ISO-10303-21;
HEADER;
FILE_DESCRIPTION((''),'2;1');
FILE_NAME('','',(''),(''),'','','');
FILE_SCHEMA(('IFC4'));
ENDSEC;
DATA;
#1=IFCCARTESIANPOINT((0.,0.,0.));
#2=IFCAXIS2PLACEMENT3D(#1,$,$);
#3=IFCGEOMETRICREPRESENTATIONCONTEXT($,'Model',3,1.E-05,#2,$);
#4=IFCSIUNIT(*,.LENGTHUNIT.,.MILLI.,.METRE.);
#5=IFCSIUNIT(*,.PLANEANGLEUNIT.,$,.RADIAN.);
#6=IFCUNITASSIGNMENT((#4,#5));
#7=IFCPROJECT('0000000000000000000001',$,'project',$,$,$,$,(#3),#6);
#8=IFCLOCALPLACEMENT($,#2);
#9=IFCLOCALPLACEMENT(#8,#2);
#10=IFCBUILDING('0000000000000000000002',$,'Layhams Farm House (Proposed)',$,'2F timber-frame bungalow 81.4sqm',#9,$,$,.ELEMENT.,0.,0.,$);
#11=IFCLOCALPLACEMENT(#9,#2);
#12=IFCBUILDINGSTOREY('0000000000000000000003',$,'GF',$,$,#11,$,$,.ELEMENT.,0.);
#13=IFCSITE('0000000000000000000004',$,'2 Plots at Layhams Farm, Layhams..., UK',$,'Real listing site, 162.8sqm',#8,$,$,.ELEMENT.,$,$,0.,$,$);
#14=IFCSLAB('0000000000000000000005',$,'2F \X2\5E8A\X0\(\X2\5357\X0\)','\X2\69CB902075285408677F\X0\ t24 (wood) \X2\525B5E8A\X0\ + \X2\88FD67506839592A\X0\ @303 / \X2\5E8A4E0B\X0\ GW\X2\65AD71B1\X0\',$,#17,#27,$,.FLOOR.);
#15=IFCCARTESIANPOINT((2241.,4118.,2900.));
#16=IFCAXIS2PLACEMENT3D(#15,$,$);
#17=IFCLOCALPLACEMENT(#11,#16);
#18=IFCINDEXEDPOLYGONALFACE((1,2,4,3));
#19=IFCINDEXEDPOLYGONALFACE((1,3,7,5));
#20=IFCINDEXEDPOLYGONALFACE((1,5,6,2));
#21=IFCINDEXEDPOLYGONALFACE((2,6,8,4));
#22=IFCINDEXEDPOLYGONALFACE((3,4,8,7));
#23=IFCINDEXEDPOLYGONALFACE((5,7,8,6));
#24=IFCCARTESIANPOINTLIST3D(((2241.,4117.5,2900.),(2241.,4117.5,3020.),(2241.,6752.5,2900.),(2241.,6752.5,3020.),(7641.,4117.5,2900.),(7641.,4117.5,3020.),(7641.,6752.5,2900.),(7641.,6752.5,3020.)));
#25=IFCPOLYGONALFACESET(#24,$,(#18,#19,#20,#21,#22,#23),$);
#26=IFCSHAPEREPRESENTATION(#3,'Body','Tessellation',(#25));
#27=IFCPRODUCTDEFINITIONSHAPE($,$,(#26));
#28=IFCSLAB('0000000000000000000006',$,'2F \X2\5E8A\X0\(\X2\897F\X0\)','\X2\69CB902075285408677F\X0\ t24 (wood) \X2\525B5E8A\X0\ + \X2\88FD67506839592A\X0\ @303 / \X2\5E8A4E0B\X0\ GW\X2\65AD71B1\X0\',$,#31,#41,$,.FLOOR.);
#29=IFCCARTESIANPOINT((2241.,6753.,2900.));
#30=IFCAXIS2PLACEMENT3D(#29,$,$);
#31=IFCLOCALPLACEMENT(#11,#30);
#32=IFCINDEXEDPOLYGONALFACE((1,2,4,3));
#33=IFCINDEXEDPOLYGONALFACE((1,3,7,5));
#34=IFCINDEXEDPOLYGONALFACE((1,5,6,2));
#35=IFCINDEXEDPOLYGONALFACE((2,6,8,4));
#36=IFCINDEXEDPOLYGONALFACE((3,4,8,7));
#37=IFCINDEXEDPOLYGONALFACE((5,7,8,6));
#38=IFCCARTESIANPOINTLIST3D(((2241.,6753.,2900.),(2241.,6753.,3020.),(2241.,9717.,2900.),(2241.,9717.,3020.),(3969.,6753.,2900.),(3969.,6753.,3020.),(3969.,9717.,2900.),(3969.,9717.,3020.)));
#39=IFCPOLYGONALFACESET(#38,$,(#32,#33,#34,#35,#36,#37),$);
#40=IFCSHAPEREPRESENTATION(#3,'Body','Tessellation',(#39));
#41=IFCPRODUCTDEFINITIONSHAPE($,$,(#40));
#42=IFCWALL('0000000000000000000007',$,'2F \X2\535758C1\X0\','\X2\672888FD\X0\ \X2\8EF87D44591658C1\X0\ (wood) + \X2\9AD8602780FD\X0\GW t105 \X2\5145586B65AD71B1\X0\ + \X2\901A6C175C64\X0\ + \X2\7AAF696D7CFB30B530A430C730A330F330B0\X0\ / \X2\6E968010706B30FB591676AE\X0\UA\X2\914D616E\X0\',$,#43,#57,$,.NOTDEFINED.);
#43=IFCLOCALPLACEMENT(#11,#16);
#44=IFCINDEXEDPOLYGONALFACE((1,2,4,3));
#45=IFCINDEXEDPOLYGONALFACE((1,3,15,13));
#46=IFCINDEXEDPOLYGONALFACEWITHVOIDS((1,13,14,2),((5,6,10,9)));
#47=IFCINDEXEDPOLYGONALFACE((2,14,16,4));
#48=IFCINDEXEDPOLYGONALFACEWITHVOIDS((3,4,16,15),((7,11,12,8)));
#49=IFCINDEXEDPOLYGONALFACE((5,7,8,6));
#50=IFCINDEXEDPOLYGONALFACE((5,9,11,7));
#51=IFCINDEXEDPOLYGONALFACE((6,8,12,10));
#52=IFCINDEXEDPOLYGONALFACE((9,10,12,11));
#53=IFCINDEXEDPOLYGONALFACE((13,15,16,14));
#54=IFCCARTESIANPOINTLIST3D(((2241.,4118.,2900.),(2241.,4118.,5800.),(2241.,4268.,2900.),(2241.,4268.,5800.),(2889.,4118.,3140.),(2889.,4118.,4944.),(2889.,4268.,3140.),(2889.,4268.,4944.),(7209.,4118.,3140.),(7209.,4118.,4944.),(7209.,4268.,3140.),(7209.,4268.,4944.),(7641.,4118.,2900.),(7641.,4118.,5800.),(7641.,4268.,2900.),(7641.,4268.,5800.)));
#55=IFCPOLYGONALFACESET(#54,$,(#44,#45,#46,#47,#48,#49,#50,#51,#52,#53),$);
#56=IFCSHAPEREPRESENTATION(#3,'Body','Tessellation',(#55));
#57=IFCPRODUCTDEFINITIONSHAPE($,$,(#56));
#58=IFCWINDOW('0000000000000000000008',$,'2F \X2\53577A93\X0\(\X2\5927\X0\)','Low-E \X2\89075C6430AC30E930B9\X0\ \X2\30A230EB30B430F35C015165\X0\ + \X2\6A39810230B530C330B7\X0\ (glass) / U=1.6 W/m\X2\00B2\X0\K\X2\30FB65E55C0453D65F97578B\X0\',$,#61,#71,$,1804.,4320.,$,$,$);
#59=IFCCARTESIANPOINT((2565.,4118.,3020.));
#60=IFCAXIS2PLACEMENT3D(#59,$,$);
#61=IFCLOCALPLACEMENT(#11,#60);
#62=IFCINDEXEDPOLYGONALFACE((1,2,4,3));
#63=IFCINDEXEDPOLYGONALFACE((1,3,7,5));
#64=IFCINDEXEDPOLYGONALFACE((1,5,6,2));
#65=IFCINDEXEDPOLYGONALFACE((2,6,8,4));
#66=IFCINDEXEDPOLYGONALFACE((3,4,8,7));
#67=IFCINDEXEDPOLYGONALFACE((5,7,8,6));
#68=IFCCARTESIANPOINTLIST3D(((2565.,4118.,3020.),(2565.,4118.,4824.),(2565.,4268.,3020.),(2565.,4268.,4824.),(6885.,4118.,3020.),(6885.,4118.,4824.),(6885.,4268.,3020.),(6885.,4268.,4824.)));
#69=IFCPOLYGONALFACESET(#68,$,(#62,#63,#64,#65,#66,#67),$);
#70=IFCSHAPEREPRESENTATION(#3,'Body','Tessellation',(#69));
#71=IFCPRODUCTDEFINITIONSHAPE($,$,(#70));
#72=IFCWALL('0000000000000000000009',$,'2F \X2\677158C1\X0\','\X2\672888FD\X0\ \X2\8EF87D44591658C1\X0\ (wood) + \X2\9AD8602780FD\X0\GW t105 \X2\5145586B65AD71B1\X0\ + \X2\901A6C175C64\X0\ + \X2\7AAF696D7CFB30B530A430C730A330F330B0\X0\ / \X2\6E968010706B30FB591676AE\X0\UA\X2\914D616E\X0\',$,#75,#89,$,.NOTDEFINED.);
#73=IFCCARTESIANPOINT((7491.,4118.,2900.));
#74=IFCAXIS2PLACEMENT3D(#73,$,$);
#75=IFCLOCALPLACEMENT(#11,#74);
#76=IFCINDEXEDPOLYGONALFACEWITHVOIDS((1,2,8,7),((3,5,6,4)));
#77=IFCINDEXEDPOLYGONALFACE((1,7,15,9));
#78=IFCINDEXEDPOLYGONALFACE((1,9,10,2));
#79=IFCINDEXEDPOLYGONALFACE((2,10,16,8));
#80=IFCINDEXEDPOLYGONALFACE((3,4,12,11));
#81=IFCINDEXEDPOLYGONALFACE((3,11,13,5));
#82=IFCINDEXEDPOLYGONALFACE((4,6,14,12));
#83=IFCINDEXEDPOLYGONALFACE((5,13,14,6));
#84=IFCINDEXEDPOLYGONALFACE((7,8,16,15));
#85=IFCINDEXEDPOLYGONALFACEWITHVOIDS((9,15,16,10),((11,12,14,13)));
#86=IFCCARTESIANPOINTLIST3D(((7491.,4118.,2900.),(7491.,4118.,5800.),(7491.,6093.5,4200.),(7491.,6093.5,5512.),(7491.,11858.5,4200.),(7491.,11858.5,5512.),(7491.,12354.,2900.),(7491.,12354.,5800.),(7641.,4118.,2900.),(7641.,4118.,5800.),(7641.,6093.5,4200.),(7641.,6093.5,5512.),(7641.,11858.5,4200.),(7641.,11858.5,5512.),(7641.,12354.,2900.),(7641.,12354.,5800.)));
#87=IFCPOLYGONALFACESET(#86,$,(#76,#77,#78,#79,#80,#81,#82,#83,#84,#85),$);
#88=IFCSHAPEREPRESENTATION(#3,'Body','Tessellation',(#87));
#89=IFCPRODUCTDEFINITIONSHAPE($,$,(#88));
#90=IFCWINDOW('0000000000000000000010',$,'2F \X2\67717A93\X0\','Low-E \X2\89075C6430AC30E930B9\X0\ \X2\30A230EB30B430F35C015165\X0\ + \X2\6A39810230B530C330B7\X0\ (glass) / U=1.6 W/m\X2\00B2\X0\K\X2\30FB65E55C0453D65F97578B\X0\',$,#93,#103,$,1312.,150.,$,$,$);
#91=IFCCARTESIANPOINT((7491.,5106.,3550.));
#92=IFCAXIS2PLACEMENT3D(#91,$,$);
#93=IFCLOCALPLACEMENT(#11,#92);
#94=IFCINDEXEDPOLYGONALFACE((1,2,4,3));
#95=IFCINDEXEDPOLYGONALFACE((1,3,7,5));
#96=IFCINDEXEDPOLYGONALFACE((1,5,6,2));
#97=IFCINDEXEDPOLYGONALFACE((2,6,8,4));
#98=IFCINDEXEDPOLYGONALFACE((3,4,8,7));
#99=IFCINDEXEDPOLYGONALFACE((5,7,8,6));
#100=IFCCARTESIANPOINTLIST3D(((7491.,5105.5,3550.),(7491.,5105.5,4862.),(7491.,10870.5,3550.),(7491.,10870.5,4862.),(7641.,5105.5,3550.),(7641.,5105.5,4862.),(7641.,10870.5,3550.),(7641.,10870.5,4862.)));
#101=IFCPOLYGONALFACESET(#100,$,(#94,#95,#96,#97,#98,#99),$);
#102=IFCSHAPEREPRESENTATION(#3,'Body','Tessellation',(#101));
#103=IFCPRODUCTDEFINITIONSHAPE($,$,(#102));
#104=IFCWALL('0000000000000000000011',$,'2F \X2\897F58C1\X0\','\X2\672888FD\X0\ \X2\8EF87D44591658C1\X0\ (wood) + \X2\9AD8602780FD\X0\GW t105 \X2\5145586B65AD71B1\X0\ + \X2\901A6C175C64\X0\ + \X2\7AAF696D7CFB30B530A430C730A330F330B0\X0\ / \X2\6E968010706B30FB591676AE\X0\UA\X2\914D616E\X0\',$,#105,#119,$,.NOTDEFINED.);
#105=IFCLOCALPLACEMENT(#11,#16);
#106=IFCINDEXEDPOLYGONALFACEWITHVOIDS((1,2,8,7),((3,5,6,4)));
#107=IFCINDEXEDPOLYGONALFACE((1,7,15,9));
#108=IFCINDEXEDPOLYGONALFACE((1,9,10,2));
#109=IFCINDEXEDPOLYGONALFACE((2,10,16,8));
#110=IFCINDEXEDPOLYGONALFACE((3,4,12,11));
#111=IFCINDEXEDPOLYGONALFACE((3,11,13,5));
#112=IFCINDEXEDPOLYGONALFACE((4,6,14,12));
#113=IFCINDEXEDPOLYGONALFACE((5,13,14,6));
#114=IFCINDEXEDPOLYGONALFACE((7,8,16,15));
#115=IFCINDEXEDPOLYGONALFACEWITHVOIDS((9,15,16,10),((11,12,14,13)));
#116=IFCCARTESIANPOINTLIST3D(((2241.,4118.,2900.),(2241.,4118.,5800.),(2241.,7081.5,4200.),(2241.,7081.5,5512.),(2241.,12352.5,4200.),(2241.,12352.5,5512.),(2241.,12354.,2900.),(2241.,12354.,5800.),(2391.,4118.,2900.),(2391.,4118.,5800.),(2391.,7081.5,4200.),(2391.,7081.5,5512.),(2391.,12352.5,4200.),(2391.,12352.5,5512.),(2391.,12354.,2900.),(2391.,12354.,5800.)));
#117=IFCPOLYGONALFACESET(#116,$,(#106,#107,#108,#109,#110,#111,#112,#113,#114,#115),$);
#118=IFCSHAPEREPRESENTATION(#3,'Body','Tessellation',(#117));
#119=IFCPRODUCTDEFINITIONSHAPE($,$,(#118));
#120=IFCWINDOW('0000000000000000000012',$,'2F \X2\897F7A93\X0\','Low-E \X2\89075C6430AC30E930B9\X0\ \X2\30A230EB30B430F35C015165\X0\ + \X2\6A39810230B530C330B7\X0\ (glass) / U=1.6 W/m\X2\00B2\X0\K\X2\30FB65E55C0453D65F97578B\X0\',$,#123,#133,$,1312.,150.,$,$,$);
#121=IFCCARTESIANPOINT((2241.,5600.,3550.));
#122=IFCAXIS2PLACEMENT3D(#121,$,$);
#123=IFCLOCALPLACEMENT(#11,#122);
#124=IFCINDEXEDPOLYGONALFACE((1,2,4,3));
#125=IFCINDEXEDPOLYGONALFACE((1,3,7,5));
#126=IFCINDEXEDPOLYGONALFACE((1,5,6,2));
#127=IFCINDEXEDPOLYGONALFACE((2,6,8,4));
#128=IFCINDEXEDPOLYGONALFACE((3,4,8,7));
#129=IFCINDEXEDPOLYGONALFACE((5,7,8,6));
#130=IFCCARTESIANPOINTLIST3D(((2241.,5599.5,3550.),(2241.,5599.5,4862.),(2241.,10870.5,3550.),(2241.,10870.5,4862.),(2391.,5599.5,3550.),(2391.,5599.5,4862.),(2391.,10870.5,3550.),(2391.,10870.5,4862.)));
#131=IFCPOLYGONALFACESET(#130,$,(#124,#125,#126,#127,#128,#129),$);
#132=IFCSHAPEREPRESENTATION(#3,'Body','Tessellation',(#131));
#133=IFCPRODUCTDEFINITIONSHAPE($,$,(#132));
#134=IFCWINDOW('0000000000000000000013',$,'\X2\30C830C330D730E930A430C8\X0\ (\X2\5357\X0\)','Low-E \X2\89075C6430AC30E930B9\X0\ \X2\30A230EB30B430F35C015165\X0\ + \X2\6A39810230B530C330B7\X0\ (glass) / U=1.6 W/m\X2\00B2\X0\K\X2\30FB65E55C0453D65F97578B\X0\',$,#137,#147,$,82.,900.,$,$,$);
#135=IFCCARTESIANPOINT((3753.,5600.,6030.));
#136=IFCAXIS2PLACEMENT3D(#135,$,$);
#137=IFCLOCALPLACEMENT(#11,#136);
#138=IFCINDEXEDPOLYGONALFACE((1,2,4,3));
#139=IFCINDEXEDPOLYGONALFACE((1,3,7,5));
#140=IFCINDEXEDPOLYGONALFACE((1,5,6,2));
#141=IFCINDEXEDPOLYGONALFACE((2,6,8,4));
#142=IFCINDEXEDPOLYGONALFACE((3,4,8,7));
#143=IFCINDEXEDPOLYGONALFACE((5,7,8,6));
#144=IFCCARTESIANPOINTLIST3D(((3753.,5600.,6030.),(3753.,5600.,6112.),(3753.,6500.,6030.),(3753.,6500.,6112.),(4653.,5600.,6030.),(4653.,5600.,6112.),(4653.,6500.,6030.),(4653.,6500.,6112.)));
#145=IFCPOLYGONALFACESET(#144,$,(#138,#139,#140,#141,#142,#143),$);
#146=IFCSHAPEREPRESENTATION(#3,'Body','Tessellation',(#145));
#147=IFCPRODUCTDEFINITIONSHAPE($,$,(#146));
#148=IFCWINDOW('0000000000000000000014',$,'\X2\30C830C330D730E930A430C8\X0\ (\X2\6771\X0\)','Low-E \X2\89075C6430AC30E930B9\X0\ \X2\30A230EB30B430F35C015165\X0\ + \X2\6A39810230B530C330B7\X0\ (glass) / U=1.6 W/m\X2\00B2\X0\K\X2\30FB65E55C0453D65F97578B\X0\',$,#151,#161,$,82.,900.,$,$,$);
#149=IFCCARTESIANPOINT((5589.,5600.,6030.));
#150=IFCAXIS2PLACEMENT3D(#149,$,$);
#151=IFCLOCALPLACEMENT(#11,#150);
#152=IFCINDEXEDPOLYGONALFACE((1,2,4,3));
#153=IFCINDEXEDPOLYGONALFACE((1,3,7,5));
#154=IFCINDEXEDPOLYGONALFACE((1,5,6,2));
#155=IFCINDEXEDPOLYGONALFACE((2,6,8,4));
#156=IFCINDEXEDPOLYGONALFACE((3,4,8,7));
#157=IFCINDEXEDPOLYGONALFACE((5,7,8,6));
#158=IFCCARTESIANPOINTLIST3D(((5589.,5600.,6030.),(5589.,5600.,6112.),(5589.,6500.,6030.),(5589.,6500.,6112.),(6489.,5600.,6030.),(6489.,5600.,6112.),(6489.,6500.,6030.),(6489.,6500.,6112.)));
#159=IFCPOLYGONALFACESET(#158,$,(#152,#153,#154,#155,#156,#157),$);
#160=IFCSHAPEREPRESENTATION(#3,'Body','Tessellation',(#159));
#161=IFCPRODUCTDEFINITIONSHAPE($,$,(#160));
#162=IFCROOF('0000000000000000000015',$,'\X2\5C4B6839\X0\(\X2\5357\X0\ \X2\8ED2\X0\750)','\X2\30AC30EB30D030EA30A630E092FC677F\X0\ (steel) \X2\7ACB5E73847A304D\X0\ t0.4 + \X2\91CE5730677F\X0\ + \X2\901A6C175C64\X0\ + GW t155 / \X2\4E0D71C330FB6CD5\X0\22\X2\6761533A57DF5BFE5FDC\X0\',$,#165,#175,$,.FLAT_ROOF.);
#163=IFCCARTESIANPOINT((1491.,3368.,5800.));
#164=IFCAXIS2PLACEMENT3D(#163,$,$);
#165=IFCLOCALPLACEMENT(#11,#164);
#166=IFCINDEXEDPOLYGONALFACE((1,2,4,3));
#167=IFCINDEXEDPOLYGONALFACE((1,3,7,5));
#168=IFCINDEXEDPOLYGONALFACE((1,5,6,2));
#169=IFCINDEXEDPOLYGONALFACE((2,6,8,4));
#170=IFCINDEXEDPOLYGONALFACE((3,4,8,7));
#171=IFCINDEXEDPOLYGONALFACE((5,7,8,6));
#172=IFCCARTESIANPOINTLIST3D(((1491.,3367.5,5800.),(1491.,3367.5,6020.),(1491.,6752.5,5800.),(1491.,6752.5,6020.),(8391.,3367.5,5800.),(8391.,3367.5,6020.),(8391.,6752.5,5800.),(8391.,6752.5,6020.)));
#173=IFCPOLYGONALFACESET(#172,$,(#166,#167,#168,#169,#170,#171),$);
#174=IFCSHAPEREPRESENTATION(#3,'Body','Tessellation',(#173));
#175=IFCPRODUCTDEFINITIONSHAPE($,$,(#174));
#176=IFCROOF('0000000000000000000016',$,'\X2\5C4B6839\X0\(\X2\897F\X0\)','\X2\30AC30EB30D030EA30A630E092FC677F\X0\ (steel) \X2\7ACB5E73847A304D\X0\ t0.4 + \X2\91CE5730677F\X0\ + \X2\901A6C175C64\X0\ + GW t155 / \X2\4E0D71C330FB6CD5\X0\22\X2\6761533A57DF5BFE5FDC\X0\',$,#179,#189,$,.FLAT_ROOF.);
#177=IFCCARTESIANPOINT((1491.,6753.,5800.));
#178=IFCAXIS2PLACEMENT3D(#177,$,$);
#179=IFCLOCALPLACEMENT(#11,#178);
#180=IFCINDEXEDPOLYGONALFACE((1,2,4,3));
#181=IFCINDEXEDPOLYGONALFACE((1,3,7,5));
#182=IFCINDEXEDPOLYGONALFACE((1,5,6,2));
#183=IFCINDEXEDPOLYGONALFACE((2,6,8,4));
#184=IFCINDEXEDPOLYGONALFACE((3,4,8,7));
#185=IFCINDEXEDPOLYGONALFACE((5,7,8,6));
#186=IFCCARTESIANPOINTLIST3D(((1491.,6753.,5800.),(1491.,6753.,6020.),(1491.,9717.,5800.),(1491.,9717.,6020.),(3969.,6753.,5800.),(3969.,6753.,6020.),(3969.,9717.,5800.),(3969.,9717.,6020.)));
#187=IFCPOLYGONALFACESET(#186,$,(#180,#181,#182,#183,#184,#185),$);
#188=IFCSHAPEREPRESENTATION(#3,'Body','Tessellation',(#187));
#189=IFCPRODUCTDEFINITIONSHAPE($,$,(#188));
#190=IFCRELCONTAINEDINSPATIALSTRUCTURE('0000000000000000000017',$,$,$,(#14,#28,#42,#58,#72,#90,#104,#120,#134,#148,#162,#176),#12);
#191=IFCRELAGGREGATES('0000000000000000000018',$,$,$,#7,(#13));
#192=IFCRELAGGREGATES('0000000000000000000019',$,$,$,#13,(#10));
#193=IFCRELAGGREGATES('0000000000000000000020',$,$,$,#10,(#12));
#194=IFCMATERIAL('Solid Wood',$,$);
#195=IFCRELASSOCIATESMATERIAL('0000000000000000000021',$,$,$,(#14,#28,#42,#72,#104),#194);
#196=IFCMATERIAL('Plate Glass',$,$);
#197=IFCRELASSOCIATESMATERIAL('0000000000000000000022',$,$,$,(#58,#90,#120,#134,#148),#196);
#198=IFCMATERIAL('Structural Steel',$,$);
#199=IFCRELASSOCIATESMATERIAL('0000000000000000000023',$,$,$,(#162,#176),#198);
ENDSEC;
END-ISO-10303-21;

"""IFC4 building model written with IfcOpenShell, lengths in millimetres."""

from ifc_helpers import new_model, si_unit, frame, frame_2d, origin, place, context, project, spatial, rectangle, extrude, material, element, fill, save


model = new_model("IFC4")

# Units and contexts
model_context = context("Model", 3, precision=1e-05, world=origin())
ifc_project = project(units=[si_unit("LENGTHUNIT", "METRE", prefix="MILLI"), si_unit("PLANEANGLEUNIT", "RADIAN")], contexts=[model_context])

# Site, building, storey
site_placement = place(None, origin())
site = spatial("IfcSite", under=ifc_project, at=site_placement, Name="2 Plots at Layhams Farm, Layhams..., UK", ObjectType="Real listing site, 162.8sqm", CompositionType="ELEMENT", RefElevation=0.0)
building_placement = place(site_placement, origin())
building = spatial("IfcBuilding", under=site, at=building_placement, Name="Layhams Farm House (Proposed)", ObjectType="2F timber-frame bungalow 81.4sqm", CompositionType="ELEMENT", ElevationOfRefHeight=0.0, ElevationOfTerrain=0.0)
storey_placement = place(building_placement, origin())
storey = spatial("IfcBuildingStorey", under=building, at=storey_placement, Name="GF", CompositionType="ELEMENT", Elevation=0.0)

# Slabs
ifc_material_1 = material(Name="Solid Wood")
slab_1_placement = place(storey_placement, frame((2241.0, 4118.0, 2900.0)))
element("IfcSlab", 1, at=slab_1_placement, inside=storey, material=ifc_material_1, Name="2F 床(南)", Description="構造用合板 t24 (wood) 剛床 + 製材根太 @303 / 床下 GW断熱", PredefinedType="FLOOR", context=model_context, shape_type="SweptSolid", body=[
    extrude(rectangle(XDim=5400.0, YDim=2635.0, at=frame_2d((2700.0, 1317.0))), frame((2241.0, 4118.0, 2900.0)), (0.0, 0.0, 1.0), 120.0),
])
slab_2_placement = place(storey_placement, frame((2241.0, 6753.0, 2900.0)))
element("IfcSlab", 2, at=slab_2_placement, inside=storey, material=ifc_material_1, Name="2F 床(西)", Description="構造用合板 t24 (wood) 剛床 + 製材根太 @303 / 床下 GW断熱", PredefinedType="FLOOR", context=model_context, shape_type="SweptSolid", body=[
    extrude(rectangle(XDim=1728.0, YDim=2964.0, at=frame_2d((864.0, 1482.0))), frame((2241.0, 6753.0, 2900.0)), (0.0, 0.0, 1.0), 120.0),
])

# Walls, openings, windows
wall_1_placement = place(storey_placement, frame((2241.0, 4118.0, 2900.0)))
wall_1 = element("IfcWall", 3, at=wall_1_placement, inside=storey, material=ifc_material_1, Name="2F 南壁", Description="木製 軸組外壁 (wood) + 高性能GW t105 充填断熱 + 通気層 + 窯業系サイディング / 準耐火・外皮UA配慮", PredefinedType="NOTDEFINED", context=model_context, shape_type="SweptSolid", body=[
    extrude(rectangle(XDim=5400.0, YDim=150.0, at=frame_2d((2700.0, 75.0))), frame((2241.0, 4118.0, 2900.0)), (0.0, 0.0, 1.0), 2900.0),
])
opening_1_placement = place(storey_placement, frame((2565.0, 4118.0, 3020.0)))
opening_1 = element("IfcOpeningElement", 4, at=opening_1_placement, cuts=wall_1, PredefinedType="NOTDEFINED", context=model_context, shape_type="SweptSolid", body=[
    extrude(rectangle(XDim=4320.0, YDim=150.0, at=frame_2d((2160.0, 75.0))), frame((2565.0, 4118.0, 3020.0)), (0.0, 0.0, 1.0), 1804.0),
])
ifc_material_2 = material(Name="Plate Glass")
window_1_placement = place(storey_placement, frame((2565.0, 4118.0, 3020.0)))
window_1 = element("IfcWindow", 5, at=window_1_placement, inside=storey, material=ifc_material_2, Name="2F 南窓(大)", Description="Low-E 複層ガラス アルゴン封入 + 樹脂サッシ (glass) / U=1.6 W/m²K・日射取得型", OverallHeight=1804.0, OverallWidth=4320.0, context=model_context, shape_type="SweptSolid", body=[
    extrude(rectangle(XDim=4320.0, YDim=150.0, at=frame_2d((2160.0, 75.0))), frame((2565.0, 4118.0, 3020.0)), (0.0, 0.0, 1.0), 1804.0),
])
fill(opening_1, window_1)
wall_2_placement = place(storey_placement, frame((7491.0, 4118.0, 2900.0)))
wall_2 = element("IfcWall", 6, at=wall_2_placement, inside=storey, material=ifc_material_1, Name="2F 東壁", Description="木製 軸組外壁 (wood) + 高性能GW t105 充填断熱 + 通気層 + 窯業系サイディング / 準耐火・外皮UA配慮", PredefinedType="NOTDEFINED", context=model_context, shape_type="SweptSolid", body=[
    extrude(rectangle(XDim=150.0, YDim=8236.0, at=frame_2d((75.0, 4118.0))), frame((7491.0, 4118.0, 2900.0)), (0.0, 0.0, 1.0), 2900.0),
])
opening_2_placement = place(storey_placement, frame((7491.0, 5106.0, 3550.0)))
opening_2 = element("IfcOpeningElement", 7, at=opening_2_placement, cuts=wall_2, PredefinedType="NOTDEFINED", context=model_context, shape_type="SweptSolid", body=[
    extrude(rectangle(XDim=150.0, YDim=5765.0, at=frame_2d((75.0, 2882.0))), frame((7491.0, 5106.0, 3550.0)), (0.0, 0.0, 1.0), 1312.0),
])
window_2_placement = place(storey_placement, frame((7491.0, 5106.0, 3550.0)))
window_2 = element("IfcWindow", 8, at=window_2_placement, inside=storey, material=ifc_material_2, Name="2F 東窓", Description="Low-E 複層ガラス アルゴン封入 + 樹脂サッシ (glass) / U=1.6 W/m²K・日射取得型", OverallHeight=1312.0, OverallWidth=150.0, context=model_context, shape_type="SweptSolid", body=[
    extrude(rectangle(XDim=150.0, YDim=5765.0, at=frame_2d((75.0, 2882.0))), frame((7491.0, 5106.0, 3550.0)), (0.0, 0.0, 1.0), 1312.0),
])
fill(opening_2, window_2)
wall_3_placement = place(storey_placement, frame((2241.0, 4118.0, 2900.0)))
wall_3 = element("IfcWall", 9, at=wall_3_placement, inside=storey, material=ifc_material_1, Name="2F 西壁", Description="木製 軸組外壁 (wood) + 高性能GW t105 充填断熱 + 通気層 + 窯業系サイディング / 準耐火・外皮UA配慮", PredefinedType="NOTDEFINED", context=model_context, shape_type="SweptSolid", body=[
    extrude(rectangle(XDim=150.0, YDim=8236.0, at=frame_2d((75.0, 4118.0))), frame((2241.0, 4118.0, 2900.0)), (0.0, 0.0, 1.0), 2900.0),
])
opening_3_placement = place(storey_placement, frame((2241.0, 5600.0, 3550.0)))
opening_3 = element("IfcOpeningElement", 10, at=opening_3_placement, cuts=wall_3, PredefinedType="NOTDEFINED", context=model_context, shape_type="SweptSolid", body=[
    extrude(rectangle(XDim=150.0, YDim=5271.0, at=frame_2d((75.0, 2635.0))), frame((2241.0, 5600.0, 3550.0)), (0.0, 0.0, 1.0), 1312.0),
])
window_3_placement = place(storey_placement, frame((2241.0, 5600.0, 3550.0)))
window_3 = element("IfcWindow", 11, at=window_3_placement, inside=storey, material=ifc_material_2, Name="2F 西窓", Description="Low-E 複層ガラス アルゴン封入 + 樹脂サッシ (glass) / U=1.6 W/m²K・日射取得型", OverallHeight=1312.0, OverallWidth=150.0, context=model_context, shape_type="SweptSolid", body=[
    extrude(rectangle(XDim=150.0, YDim=5271.0, at=frame_2d((75.0, 2635.0))), frame((2241.0, 5600.0, 3550.0)), (0.0, 0.0, 1.0), 1312.0),
])
fill(opening_3, window_3)

# Windows
window_4_placement = place(storey_placement, frame((3753.0, 5600.0, 6030.0)))
element("IfcWindow", 12, at=window_4_placement, inside=storey, material=ifc_material_2, Name="トップライト (南)", Description="Low-E 複層ガラス アルゴン封入 + 樹脂サッシ (glass) / U=1.6 W/m²K・日射取得型", OverallHeight=82.0, OverallWidth=900.0, context=model_context, shape_type="SweptSolid", body=[
    extrude(rectangle(XDim=900.0, YDim=900.0, at=frame_2d((450.0, 450.0))), frame((3753.0, 5600.0, 6030.0)), (0.0, 0.0, 1.0), 82.0),
])
window_5_placement = place(storey_placement, frame((5589.0, 5600.0, 6030.0)))
element("IfcWindow", 13, at=window_5_placement, inside=storey, material=ifc_material_2, Name="トップライト (東)", Description="Low-E 複層ガラス アルゴン封入 + 樹脂サッシ (glass) / U=1.6 W/m²K・日射取得型", OverallHeight=82.0, OverallWidth=900.0, context=model_context, shape_type="SweptSolid", body=[
    extrude(rectangle(XDim=900.0, YDim=900.0, at=frame_2d((450.0, 450.0))), frame((5589.0, 5600.0, 6030.0)), (0.0, 0.0, 1.0), 82.0),
])

# Roofs
ifc_material_3 = material(Name="Structural Steel")
roof_1_placement = place(storey_placement, frame((1491.0, 3368.0, 5800.0)))
element("IfcRoof", 14, at=roof_1_placement, inside=storey, material=ifc_material_3, Name="屋根(南 軒750)", Description="ガルバリウム鋼板 (steel) 立平葺き t0.4 + 野地板 + 通気層 + GW t155 / 不燃・法22条区域対応", PredefinedType="FLAT_ROOF", context=model_context, shape_type="SweptSolid", body=[
    extrude(rectangle(XDim=6900.0, YDim=3385.0, at=frame_2d((3450.0, 1692.0))), frame((1491.0, 3368.0, 5800.0)), (0.0, 0.0, 1.0), 220.0),
])
roof_2_placement = place(storey_placement, frame((1491.0, 6753.0, 5800.0)))
element("IfcRoof", 15, at=roof_2_placement, inside=storey, material=ifc_material_3, Name="屋根(西)", Description="ガルバリウム鋼板 (steel) 立平葺き t0.4 + 野地板 + 通気層 + GW t155 / 不燃・法22条区域対応", PredefinedType="FLAT_ROOF", context=model_context, shape_type="SweptSolid", body=[
    extrude(rectangle(XDim=2478.0, YDim=2964.0, at=frame_2d((1239.0, 1482.0))), frame((1491.0, 6753.0, 5800.0)), (0.0, 0.0, 1.0), 220.0),
])

save(model, "model.ifc")
